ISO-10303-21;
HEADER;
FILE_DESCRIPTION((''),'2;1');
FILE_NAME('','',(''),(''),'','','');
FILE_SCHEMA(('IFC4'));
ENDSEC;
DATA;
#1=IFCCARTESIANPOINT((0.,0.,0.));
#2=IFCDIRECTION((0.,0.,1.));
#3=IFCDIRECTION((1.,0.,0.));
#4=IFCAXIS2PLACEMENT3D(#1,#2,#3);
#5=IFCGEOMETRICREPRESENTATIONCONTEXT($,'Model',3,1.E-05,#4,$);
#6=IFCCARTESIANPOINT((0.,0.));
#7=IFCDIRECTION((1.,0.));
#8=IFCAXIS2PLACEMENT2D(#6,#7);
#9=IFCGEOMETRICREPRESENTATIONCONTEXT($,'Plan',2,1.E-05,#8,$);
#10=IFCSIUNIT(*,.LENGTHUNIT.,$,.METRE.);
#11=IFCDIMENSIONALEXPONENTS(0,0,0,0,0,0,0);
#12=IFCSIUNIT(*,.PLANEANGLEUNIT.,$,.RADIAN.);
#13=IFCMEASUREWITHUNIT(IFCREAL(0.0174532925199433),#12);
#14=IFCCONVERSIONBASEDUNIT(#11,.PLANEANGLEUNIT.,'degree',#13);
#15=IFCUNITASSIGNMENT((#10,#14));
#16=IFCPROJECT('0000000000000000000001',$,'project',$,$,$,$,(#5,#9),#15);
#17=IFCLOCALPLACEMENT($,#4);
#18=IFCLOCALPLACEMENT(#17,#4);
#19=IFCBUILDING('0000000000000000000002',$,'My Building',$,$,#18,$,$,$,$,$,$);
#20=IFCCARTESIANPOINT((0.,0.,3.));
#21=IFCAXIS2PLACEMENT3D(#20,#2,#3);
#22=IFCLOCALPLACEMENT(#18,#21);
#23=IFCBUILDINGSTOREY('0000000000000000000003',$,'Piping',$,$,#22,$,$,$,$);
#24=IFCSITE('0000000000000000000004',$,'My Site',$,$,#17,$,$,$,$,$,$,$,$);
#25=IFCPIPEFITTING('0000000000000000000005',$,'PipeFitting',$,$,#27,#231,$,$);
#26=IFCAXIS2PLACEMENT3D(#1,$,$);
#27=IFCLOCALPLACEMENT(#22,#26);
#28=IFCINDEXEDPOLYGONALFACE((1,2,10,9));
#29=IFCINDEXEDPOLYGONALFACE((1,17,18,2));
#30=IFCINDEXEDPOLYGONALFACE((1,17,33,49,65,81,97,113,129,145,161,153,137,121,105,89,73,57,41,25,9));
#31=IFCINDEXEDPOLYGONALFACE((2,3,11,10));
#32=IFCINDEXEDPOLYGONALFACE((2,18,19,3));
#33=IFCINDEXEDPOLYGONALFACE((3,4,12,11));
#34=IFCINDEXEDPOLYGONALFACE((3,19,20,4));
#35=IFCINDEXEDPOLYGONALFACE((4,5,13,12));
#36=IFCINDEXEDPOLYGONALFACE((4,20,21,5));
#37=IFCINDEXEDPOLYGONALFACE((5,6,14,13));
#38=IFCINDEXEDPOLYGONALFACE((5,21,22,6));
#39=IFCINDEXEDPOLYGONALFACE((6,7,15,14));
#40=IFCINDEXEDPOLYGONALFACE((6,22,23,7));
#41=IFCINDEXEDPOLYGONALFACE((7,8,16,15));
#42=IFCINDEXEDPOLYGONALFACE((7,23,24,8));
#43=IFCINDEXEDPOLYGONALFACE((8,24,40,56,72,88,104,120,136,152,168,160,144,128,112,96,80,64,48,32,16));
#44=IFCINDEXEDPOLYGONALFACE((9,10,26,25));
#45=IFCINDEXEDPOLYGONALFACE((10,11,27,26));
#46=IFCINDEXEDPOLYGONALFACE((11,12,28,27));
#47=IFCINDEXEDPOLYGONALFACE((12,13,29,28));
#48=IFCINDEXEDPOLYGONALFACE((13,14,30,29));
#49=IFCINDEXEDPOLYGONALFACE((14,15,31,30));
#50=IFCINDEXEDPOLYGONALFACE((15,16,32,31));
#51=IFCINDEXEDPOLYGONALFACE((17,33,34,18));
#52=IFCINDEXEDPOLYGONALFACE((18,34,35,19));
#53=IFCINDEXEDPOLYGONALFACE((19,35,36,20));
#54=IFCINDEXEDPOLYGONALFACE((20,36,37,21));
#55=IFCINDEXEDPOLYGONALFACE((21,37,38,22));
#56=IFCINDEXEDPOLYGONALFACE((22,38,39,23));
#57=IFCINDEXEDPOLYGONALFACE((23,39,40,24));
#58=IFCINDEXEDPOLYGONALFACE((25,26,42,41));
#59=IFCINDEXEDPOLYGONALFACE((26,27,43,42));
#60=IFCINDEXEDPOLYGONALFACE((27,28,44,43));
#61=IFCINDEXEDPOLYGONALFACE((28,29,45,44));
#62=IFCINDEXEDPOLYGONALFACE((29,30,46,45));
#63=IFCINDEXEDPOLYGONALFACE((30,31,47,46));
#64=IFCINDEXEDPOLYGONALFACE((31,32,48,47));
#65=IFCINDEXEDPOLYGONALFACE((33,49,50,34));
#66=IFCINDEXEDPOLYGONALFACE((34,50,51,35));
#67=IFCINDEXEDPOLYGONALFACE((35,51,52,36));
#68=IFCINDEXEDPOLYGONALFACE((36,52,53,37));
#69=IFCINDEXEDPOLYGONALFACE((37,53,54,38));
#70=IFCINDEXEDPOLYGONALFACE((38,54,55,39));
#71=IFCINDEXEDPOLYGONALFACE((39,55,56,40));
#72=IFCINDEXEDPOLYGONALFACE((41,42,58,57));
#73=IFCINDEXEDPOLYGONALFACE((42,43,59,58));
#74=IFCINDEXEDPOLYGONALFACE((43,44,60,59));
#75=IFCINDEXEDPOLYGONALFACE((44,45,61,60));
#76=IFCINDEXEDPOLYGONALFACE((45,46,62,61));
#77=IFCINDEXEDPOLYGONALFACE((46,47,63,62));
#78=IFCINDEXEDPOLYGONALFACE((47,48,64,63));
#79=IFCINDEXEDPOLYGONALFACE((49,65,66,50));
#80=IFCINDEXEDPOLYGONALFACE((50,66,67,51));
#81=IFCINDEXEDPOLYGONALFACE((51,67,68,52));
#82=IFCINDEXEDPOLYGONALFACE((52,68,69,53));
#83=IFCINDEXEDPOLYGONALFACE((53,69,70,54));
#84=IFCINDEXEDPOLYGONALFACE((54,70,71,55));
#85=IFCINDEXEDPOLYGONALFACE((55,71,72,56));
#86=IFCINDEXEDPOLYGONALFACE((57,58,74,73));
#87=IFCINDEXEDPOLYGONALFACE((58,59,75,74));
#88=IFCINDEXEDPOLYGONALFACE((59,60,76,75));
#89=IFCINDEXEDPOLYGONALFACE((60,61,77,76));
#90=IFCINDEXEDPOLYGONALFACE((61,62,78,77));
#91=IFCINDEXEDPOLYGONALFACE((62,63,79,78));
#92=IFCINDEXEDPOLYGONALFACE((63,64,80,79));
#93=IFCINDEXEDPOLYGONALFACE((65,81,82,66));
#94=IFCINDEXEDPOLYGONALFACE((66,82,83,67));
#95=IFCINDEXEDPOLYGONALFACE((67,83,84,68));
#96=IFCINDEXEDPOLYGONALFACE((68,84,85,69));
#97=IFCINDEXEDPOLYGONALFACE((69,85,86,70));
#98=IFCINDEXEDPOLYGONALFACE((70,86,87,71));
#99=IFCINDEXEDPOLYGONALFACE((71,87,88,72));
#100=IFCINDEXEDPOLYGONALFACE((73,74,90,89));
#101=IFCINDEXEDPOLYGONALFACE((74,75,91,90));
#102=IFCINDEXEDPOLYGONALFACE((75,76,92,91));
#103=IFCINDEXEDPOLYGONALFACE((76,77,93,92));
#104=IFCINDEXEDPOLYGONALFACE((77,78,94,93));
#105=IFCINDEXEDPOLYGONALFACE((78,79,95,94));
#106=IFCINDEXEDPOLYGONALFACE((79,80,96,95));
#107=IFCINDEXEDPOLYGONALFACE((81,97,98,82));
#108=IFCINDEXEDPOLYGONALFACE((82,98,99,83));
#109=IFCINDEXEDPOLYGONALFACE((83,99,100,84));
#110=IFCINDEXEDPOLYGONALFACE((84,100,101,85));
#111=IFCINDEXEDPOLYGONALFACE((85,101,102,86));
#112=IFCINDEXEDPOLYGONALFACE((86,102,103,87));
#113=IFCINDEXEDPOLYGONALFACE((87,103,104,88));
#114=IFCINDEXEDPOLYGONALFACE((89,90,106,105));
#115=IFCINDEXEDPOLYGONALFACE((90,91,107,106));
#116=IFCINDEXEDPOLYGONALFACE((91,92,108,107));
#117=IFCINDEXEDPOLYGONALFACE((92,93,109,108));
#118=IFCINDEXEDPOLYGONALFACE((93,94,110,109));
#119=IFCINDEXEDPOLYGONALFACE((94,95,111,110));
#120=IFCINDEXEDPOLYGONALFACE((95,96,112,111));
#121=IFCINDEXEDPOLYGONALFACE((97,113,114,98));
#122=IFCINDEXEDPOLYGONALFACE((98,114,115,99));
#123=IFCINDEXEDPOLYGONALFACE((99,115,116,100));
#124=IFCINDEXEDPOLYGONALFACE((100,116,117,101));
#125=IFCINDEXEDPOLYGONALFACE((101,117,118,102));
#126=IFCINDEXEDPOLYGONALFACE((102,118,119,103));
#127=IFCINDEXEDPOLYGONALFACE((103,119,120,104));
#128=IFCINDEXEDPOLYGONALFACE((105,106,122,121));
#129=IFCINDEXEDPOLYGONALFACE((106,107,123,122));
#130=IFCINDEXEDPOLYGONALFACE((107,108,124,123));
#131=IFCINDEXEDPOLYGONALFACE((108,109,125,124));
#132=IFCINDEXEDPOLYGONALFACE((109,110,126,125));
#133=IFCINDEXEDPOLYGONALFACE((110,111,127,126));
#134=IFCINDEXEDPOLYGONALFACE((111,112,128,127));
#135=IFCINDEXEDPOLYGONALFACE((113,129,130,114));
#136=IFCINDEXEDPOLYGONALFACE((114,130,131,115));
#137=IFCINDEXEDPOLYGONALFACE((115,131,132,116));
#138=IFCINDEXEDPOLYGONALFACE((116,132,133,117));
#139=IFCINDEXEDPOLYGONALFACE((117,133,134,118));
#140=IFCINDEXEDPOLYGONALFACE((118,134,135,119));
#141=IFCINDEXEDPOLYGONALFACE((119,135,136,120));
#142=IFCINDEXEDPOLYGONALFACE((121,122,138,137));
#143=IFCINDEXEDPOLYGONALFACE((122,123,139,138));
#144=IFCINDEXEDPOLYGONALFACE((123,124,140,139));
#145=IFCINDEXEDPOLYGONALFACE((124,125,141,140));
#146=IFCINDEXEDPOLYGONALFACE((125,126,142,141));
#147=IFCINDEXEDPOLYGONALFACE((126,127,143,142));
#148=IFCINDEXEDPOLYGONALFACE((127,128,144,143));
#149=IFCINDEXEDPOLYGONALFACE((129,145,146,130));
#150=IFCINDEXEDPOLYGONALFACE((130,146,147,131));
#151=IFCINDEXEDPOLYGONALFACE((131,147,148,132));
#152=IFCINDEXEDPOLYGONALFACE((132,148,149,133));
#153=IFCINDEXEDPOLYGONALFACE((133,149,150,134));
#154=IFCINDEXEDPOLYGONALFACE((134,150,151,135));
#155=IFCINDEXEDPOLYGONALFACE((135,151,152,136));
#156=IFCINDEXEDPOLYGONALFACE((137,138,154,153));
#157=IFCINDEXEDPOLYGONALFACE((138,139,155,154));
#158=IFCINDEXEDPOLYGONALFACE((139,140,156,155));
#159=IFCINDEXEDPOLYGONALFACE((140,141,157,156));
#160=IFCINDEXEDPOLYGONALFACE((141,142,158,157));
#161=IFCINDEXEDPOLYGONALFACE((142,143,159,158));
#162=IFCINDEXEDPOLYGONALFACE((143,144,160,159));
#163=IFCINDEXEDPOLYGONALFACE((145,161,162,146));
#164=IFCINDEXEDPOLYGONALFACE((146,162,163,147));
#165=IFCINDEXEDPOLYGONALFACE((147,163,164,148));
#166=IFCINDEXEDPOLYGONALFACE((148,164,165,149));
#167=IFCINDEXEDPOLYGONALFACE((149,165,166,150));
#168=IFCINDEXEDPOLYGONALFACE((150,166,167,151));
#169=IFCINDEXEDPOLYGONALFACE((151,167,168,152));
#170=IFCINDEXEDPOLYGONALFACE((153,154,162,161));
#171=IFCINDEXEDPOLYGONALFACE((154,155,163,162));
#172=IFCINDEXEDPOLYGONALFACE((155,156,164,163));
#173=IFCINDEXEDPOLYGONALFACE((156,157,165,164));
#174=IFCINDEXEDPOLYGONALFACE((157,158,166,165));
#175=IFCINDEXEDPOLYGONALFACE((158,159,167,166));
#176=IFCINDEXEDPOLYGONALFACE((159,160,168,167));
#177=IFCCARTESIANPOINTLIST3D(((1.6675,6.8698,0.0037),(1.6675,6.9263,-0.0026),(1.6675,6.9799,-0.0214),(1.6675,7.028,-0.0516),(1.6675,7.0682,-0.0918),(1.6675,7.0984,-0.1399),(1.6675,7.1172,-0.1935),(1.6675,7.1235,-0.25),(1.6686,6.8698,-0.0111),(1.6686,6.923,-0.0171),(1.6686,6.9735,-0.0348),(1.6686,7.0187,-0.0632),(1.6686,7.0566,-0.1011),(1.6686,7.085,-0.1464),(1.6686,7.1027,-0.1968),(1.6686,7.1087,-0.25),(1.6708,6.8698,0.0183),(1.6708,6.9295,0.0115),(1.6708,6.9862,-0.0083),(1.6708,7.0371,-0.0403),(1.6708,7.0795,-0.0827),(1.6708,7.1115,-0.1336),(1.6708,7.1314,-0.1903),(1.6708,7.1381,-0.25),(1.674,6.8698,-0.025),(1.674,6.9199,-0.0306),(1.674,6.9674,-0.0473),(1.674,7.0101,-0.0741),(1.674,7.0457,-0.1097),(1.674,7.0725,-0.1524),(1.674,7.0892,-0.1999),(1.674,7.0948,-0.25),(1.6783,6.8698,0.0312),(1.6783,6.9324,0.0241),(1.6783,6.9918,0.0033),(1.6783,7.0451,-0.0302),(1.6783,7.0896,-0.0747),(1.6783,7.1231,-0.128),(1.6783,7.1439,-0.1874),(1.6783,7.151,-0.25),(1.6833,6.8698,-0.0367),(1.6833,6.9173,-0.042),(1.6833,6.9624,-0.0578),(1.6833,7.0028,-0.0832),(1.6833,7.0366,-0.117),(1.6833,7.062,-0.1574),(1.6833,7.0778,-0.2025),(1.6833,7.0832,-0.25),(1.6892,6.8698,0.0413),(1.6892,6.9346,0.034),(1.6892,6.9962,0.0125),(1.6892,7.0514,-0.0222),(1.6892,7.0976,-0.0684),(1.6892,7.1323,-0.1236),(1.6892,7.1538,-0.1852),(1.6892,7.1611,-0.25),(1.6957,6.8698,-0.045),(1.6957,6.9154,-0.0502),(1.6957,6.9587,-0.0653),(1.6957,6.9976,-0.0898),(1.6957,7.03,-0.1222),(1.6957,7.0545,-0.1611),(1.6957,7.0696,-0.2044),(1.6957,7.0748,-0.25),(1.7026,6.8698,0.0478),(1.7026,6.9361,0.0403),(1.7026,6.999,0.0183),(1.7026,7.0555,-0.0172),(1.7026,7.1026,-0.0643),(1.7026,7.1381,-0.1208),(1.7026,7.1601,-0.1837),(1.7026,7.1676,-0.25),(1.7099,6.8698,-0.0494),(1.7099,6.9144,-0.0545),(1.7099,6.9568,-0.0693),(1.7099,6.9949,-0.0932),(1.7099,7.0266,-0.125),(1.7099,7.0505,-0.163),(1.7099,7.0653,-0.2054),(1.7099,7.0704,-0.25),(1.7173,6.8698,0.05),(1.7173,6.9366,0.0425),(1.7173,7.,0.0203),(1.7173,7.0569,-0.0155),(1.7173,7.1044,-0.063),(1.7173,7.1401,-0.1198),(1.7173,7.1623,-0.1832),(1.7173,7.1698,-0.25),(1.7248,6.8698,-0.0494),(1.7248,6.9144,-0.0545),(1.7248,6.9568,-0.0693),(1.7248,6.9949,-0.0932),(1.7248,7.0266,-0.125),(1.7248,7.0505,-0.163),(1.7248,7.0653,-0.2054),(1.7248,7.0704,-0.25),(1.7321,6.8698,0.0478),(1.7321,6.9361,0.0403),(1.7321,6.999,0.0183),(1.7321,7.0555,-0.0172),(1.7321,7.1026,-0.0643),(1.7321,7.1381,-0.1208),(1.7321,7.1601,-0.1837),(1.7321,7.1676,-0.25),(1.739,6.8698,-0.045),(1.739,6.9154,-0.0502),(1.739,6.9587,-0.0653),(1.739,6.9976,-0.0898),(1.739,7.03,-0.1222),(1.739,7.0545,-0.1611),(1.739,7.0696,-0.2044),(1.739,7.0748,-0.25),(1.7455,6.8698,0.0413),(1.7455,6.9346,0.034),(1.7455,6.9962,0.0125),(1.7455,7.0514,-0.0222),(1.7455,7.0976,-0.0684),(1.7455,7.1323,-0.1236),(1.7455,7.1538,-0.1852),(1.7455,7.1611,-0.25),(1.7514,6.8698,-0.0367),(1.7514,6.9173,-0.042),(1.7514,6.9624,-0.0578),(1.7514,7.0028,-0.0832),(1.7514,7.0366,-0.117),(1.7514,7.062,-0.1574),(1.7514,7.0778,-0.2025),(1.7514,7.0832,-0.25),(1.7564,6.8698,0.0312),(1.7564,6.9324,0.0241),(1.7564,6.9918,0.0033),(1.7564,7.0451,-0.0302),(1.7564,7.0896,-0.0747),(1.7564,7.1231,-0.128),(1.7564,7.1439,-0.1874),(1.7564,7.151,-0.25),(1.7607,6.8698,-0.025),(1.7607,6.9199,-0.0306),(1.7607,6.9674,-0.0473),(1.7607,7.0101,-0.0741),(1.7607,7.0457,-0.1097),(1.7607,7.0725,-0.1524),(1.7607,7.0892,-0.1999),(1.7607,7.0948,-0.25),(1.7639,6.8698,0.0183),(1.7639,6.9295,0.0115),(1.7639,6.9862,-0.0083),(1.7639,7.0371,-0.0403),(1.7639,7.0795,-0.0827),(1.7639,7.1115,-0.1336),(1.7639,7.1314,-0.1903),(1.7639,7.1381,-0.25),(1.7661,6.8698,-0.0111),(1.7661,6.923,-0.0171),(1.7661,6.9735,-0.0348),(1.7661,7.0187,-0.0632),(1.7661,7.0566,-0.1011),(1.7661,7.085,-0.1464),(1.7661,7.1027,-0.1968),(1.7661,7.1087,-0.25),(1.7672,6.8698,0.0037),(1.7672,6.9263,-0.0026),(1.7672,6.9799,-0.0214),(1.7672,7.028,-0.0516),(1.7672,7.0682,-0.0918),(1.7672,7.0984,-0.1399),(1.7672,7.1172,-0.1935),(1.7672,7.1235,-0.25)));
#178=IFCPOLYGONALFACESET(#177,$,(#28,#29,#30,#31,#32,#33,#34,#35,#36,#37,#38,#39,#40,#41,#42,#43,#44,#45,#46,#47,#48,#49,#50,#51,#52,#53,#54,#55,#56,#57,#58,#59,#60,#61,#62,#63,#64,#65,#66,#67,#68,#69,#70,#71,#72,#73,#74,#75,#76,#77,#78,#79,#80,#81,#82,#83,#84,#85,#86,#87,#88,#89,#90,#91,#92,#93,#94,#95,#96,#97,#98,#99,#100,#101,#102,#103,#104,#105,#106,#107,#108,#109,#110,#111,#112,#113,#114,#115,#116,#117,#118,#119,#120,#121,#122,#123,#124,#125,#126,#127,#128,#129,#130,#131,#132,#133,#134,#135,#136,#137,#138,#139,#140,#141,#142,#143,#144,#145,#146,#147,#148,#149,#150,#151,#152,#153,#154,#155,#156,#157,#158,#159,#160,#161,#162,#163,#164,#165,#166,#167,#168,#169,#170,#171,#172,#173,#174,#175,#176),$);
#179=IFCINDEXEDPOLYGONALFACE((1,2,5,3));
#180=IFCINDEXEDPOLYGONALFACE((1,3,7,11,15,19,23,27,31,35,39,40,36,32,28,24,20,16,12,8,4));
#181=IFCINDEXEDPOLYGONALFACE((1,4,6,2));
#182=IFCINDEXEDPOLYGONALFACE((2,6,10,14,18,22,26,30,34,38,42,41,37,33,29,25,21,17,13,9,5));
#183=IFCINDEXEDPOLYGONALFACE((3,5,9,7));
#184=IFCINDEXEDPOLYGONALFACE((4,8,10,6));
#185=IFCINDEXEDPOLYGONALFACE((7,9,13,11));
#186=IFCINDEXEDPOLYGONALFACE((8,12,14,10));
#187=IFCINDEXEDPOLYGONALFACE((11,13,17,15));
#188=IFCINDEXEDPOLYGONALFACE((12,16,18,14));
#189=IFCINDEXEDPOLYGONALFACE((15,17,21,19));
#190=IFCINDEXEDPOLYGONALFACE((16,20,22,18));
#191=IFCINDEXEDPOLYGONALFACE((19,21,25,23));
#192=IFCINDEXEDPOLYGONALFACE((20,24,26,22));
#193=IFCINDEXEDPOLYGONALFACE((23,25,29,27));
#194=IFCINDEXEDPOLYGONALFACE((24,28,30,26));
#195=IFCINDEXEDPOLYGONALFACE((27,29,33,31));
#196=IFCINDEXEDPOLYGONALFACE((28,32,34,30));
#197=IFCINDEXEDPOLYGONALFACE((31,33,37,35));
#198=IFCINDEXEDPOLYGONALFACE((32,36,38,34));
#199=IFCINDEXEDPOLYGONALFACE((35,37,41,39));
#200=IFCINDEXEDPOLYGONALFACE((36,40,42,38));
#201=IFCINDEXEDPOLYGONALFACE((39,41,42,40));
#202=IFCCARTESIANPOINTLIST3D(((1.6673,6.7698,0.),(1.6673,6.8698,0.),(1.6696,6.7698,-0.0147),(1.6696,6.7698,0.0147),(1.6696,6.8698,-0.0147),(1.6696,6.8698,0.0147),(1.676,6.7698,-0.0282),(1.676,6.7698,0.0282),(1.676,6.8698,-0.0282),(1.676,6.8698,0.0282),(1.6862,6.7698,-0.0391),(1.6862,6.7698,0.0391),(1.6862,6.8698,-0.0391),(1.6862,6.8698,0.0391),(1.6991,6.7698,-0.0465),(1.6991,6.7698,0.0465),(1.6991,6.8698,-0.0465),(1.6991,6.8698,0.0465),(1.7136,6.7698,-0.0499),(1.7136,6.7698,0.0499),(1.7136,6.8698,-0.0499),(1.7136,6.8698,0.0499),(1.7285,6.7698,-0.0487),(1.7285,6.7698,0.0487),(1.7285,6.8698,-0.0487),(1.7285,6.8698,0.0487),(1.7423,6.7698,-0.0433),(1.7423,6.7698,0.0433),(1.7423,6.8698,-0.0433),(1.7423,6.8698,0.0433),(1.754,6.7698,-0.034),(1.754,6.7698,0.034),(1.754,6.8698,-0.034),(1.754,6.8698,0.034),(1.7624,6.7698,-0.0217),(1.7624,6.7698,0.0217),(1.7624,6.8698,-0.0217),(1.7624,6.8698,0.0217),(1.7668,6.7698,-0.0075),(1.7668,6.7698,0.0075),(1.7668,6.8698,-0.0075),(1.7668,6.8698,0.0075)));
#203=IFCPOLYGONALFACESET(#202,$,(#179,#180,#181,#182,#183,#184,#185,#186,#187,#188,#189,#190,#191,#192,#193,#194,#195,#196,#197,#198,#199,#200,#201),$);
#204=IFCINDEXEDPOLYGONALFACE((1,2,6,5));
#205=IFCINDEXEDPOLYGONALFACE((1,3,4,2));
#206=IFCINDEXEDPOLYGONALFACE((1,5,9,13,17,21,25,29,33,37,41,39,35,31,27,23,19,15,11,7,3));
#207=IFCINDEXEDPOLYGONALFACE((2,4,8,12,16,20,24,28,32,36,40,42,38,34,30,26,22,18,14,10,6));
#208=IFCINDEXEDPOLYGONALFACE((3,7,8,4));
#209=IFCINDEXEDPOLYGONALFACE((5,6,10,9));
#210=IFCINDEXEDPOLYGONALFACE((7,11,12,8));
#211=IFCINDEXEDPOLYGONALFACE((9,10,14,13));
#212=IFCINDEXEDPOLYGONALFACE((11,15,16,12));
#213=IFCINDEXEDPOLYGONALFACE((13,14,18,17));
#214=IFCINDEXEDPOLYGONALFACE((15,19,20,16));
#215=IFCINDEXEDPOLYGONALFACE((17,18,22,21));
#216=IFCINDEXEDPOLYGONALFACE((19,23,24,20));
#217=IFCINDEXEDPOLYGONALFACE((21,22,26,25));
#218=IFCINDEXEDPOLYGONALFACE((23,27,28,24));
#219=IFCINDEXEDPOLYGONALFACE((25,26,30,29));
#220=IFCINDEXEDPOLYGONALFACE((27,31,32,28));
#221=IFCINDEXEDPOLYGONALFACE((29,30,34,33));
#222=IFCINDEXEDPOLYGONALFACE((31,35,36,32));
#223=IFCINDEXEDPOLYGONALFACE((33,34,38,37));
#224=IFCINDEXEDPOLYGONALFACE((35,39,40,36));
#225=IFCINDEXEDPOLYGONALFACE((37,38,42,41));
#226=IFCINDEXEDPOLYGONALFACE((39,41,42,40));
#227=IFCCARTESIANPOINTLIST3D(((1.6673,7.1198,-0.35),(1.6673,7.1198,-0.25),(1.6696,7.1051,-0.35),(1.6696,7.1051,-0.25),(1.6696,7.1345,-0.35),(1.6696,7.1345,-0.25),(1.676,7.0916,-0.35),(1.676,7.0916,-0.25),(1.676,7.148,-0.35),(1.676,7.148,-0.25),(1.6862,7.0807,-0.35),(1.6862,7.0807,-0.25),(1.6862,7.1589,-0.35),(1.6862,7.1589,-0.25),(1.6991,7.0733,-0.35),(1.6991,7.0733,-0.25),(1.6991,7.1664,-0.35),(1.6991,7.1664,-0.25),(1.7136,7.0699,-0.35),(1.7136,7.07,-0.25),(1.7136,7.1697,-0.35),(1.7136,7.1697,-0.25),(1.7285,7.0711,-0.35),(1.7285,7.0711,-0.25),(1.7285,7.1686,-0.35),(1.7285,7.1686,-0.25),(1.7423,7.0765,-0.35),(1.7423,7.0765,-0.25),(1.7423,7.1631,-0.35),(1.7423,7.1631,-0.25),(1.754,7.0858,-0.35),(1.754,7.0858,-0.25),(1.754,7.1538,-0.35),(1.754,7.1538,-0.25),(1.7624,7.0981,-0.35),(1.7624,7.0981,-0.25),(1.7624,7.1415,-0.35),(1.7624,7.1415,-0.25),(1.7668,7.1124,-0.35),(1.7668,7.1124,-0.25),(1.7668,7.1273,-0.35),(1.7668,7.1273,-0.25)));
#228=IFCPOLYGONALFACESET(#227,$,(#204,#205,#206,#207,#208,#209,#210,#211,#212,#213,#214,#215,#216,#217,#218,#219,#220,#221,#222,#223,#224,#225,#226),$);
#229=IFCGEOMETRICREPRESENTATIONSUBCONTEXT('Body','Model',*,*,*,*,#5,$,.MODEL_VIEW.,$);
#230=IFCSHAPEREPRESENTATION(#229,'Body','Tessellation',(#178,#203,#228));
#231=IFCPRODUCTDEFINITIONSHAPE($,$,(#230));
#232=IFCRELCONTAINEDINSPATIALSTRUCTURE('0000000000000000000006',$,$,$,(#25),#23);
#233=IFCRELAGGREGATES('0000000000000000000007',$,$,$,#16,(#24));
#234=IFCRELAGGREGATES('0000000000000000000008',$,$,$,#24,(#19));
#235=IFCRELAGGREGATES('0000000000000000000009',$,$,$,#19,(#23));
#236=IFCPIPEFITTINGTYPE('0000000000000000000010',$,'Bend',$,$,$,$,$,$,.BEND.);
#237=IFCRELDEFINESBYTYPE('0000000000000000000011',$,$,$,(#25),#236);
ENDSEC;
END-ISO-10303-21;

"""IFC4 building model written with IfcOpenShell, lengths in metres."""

from ifc_helpers import new_model, entity, si_unit, converted_unit, frame, origin_with_axes, origin_2d_with_axis, place, context, subcontext, project, spatial, line, indexed_curve, circle, outline, extrude, source, transform, mapped, type_object, type_shapes, element, save


model = new_model("IFC4")

# Units and contexts
model_context = context("Model", 3, precision=1e-05, world=origin_with_axes())
plan_context = context("Plan", 2, precision=1e-05, world=origin_2d_with_axis())
body_context = subcontext(model_context, "Body", "Model", "MODEL_VIEW")
ifc_project = project(units=[si_unit("LENGTHUNIT", "METRE"), converted_unit("PLANEANGLEUNIT", "degree", entity("IfcReal", 0.0174532925199433), si_unit("PLANEANGLEUNIT", "RADIAN"), dimensions=[0, 0, 0, 0, 0, 0, 0])], contexts=[model_context, plan_context])

# Site, building, storey
site_placement = place(None, origin_with_axes())
site = spatial("IfcSite", under=ifc_project, at=site_placement, Name="My Site")
building_placement = place(site_placement, origin_with_axes())
building = spatial("IfcBuilding", under=site, at=building_placement, Name="My Building")
storey_placement = place(building_placement, frame((0.0, 0.0, 3.0), z_axis=(0.0, 0.0, 1.0), x_axis=(1.0, 0.0, 0.0)))
storey = spatial("IfcBuildingStorey", under=building, at=storey_placement, Name="Piping")

# Pipe fitting, opening
pipe_fitting_type = type_object("IfcPipeFittingType", Name="Bend", PredefinedType="BEND")
shared_shape = source(origin_with_axes(), body_context, "Body", "SolidModel", [
    entity("IfcSweptDiskSolid", entity("IfcIndexedPolyCurve", entity("IfcCartesianPointList3D", [[0.0, 0.0, 0.1], [0.0, -0.0732, 0.2768], [0.0, -0.25, 0.35]]), [entity("IfcArcIndex", [1, 2, 3])]), 0.05),
    extrude(circle(Radius=0.05), origin_with_axes(), (0.0, 0.0, 1.0), 0.1),
    extrude(circle(Radius=0.05), frame((0.0, -0.25, 0.35), z_axis=(0.0, -1.0, 0.0), x_axis=(1.0, 0.0, 0.0)), (0.0, 0.0, 1.0), 0.1),
])
type_shapes(pipe_fitting_type, [shared_shape])
pipe_fitting_1_placement = place(storey_placement, frame((1.7173, 6.7698, 0.0), z_axis=(0.0, 1.0, 0.0), x_axis=(-1.0, 0.0, 0.0)))
pipe_fitting_1 = element("IfcPipeFitting", 1, at=pipe_fitting_1_placement, inside=storey, type_object=pipe_fitting_type, Name="PipeFitting", context=body_context, shape_type="MappedRepresentation", body=[
    mapped(shared_shape, transform((0.0, 0.0, 0.0), x_axis=(1.0, 0.0, 0.0), y_axis=(0.0, 1.0, 0.0), z_axis=(0.0, 0.0, 1.0), scale=1.0)),
])
opening_1_placement = place(pipe_fitting_1_placement, frame((1.7174, -3.0, -6.7698), z_axis=(0.0, 1.0, 0.0), x_axis=(-1.0, 0.0, 0.0)))
element("IfcOpeningElement", 2, at=opening_1_placement, cuts=pipe_fitting_1, PredefinedType="OPENING", context=body_context, shape_type="SweptSolid", body=[
    extrude(outline(indexed_curve([(0.0, 0.0), (0.5, 0.0), (0.5, 0.5), (0.0, 0.5)], segments=[line(1, 2, 3, 4, 1)])), origin_with_axes(), (0.0, 0.0, 1.0), 0.5),
])

save(model, "model.ifc")
